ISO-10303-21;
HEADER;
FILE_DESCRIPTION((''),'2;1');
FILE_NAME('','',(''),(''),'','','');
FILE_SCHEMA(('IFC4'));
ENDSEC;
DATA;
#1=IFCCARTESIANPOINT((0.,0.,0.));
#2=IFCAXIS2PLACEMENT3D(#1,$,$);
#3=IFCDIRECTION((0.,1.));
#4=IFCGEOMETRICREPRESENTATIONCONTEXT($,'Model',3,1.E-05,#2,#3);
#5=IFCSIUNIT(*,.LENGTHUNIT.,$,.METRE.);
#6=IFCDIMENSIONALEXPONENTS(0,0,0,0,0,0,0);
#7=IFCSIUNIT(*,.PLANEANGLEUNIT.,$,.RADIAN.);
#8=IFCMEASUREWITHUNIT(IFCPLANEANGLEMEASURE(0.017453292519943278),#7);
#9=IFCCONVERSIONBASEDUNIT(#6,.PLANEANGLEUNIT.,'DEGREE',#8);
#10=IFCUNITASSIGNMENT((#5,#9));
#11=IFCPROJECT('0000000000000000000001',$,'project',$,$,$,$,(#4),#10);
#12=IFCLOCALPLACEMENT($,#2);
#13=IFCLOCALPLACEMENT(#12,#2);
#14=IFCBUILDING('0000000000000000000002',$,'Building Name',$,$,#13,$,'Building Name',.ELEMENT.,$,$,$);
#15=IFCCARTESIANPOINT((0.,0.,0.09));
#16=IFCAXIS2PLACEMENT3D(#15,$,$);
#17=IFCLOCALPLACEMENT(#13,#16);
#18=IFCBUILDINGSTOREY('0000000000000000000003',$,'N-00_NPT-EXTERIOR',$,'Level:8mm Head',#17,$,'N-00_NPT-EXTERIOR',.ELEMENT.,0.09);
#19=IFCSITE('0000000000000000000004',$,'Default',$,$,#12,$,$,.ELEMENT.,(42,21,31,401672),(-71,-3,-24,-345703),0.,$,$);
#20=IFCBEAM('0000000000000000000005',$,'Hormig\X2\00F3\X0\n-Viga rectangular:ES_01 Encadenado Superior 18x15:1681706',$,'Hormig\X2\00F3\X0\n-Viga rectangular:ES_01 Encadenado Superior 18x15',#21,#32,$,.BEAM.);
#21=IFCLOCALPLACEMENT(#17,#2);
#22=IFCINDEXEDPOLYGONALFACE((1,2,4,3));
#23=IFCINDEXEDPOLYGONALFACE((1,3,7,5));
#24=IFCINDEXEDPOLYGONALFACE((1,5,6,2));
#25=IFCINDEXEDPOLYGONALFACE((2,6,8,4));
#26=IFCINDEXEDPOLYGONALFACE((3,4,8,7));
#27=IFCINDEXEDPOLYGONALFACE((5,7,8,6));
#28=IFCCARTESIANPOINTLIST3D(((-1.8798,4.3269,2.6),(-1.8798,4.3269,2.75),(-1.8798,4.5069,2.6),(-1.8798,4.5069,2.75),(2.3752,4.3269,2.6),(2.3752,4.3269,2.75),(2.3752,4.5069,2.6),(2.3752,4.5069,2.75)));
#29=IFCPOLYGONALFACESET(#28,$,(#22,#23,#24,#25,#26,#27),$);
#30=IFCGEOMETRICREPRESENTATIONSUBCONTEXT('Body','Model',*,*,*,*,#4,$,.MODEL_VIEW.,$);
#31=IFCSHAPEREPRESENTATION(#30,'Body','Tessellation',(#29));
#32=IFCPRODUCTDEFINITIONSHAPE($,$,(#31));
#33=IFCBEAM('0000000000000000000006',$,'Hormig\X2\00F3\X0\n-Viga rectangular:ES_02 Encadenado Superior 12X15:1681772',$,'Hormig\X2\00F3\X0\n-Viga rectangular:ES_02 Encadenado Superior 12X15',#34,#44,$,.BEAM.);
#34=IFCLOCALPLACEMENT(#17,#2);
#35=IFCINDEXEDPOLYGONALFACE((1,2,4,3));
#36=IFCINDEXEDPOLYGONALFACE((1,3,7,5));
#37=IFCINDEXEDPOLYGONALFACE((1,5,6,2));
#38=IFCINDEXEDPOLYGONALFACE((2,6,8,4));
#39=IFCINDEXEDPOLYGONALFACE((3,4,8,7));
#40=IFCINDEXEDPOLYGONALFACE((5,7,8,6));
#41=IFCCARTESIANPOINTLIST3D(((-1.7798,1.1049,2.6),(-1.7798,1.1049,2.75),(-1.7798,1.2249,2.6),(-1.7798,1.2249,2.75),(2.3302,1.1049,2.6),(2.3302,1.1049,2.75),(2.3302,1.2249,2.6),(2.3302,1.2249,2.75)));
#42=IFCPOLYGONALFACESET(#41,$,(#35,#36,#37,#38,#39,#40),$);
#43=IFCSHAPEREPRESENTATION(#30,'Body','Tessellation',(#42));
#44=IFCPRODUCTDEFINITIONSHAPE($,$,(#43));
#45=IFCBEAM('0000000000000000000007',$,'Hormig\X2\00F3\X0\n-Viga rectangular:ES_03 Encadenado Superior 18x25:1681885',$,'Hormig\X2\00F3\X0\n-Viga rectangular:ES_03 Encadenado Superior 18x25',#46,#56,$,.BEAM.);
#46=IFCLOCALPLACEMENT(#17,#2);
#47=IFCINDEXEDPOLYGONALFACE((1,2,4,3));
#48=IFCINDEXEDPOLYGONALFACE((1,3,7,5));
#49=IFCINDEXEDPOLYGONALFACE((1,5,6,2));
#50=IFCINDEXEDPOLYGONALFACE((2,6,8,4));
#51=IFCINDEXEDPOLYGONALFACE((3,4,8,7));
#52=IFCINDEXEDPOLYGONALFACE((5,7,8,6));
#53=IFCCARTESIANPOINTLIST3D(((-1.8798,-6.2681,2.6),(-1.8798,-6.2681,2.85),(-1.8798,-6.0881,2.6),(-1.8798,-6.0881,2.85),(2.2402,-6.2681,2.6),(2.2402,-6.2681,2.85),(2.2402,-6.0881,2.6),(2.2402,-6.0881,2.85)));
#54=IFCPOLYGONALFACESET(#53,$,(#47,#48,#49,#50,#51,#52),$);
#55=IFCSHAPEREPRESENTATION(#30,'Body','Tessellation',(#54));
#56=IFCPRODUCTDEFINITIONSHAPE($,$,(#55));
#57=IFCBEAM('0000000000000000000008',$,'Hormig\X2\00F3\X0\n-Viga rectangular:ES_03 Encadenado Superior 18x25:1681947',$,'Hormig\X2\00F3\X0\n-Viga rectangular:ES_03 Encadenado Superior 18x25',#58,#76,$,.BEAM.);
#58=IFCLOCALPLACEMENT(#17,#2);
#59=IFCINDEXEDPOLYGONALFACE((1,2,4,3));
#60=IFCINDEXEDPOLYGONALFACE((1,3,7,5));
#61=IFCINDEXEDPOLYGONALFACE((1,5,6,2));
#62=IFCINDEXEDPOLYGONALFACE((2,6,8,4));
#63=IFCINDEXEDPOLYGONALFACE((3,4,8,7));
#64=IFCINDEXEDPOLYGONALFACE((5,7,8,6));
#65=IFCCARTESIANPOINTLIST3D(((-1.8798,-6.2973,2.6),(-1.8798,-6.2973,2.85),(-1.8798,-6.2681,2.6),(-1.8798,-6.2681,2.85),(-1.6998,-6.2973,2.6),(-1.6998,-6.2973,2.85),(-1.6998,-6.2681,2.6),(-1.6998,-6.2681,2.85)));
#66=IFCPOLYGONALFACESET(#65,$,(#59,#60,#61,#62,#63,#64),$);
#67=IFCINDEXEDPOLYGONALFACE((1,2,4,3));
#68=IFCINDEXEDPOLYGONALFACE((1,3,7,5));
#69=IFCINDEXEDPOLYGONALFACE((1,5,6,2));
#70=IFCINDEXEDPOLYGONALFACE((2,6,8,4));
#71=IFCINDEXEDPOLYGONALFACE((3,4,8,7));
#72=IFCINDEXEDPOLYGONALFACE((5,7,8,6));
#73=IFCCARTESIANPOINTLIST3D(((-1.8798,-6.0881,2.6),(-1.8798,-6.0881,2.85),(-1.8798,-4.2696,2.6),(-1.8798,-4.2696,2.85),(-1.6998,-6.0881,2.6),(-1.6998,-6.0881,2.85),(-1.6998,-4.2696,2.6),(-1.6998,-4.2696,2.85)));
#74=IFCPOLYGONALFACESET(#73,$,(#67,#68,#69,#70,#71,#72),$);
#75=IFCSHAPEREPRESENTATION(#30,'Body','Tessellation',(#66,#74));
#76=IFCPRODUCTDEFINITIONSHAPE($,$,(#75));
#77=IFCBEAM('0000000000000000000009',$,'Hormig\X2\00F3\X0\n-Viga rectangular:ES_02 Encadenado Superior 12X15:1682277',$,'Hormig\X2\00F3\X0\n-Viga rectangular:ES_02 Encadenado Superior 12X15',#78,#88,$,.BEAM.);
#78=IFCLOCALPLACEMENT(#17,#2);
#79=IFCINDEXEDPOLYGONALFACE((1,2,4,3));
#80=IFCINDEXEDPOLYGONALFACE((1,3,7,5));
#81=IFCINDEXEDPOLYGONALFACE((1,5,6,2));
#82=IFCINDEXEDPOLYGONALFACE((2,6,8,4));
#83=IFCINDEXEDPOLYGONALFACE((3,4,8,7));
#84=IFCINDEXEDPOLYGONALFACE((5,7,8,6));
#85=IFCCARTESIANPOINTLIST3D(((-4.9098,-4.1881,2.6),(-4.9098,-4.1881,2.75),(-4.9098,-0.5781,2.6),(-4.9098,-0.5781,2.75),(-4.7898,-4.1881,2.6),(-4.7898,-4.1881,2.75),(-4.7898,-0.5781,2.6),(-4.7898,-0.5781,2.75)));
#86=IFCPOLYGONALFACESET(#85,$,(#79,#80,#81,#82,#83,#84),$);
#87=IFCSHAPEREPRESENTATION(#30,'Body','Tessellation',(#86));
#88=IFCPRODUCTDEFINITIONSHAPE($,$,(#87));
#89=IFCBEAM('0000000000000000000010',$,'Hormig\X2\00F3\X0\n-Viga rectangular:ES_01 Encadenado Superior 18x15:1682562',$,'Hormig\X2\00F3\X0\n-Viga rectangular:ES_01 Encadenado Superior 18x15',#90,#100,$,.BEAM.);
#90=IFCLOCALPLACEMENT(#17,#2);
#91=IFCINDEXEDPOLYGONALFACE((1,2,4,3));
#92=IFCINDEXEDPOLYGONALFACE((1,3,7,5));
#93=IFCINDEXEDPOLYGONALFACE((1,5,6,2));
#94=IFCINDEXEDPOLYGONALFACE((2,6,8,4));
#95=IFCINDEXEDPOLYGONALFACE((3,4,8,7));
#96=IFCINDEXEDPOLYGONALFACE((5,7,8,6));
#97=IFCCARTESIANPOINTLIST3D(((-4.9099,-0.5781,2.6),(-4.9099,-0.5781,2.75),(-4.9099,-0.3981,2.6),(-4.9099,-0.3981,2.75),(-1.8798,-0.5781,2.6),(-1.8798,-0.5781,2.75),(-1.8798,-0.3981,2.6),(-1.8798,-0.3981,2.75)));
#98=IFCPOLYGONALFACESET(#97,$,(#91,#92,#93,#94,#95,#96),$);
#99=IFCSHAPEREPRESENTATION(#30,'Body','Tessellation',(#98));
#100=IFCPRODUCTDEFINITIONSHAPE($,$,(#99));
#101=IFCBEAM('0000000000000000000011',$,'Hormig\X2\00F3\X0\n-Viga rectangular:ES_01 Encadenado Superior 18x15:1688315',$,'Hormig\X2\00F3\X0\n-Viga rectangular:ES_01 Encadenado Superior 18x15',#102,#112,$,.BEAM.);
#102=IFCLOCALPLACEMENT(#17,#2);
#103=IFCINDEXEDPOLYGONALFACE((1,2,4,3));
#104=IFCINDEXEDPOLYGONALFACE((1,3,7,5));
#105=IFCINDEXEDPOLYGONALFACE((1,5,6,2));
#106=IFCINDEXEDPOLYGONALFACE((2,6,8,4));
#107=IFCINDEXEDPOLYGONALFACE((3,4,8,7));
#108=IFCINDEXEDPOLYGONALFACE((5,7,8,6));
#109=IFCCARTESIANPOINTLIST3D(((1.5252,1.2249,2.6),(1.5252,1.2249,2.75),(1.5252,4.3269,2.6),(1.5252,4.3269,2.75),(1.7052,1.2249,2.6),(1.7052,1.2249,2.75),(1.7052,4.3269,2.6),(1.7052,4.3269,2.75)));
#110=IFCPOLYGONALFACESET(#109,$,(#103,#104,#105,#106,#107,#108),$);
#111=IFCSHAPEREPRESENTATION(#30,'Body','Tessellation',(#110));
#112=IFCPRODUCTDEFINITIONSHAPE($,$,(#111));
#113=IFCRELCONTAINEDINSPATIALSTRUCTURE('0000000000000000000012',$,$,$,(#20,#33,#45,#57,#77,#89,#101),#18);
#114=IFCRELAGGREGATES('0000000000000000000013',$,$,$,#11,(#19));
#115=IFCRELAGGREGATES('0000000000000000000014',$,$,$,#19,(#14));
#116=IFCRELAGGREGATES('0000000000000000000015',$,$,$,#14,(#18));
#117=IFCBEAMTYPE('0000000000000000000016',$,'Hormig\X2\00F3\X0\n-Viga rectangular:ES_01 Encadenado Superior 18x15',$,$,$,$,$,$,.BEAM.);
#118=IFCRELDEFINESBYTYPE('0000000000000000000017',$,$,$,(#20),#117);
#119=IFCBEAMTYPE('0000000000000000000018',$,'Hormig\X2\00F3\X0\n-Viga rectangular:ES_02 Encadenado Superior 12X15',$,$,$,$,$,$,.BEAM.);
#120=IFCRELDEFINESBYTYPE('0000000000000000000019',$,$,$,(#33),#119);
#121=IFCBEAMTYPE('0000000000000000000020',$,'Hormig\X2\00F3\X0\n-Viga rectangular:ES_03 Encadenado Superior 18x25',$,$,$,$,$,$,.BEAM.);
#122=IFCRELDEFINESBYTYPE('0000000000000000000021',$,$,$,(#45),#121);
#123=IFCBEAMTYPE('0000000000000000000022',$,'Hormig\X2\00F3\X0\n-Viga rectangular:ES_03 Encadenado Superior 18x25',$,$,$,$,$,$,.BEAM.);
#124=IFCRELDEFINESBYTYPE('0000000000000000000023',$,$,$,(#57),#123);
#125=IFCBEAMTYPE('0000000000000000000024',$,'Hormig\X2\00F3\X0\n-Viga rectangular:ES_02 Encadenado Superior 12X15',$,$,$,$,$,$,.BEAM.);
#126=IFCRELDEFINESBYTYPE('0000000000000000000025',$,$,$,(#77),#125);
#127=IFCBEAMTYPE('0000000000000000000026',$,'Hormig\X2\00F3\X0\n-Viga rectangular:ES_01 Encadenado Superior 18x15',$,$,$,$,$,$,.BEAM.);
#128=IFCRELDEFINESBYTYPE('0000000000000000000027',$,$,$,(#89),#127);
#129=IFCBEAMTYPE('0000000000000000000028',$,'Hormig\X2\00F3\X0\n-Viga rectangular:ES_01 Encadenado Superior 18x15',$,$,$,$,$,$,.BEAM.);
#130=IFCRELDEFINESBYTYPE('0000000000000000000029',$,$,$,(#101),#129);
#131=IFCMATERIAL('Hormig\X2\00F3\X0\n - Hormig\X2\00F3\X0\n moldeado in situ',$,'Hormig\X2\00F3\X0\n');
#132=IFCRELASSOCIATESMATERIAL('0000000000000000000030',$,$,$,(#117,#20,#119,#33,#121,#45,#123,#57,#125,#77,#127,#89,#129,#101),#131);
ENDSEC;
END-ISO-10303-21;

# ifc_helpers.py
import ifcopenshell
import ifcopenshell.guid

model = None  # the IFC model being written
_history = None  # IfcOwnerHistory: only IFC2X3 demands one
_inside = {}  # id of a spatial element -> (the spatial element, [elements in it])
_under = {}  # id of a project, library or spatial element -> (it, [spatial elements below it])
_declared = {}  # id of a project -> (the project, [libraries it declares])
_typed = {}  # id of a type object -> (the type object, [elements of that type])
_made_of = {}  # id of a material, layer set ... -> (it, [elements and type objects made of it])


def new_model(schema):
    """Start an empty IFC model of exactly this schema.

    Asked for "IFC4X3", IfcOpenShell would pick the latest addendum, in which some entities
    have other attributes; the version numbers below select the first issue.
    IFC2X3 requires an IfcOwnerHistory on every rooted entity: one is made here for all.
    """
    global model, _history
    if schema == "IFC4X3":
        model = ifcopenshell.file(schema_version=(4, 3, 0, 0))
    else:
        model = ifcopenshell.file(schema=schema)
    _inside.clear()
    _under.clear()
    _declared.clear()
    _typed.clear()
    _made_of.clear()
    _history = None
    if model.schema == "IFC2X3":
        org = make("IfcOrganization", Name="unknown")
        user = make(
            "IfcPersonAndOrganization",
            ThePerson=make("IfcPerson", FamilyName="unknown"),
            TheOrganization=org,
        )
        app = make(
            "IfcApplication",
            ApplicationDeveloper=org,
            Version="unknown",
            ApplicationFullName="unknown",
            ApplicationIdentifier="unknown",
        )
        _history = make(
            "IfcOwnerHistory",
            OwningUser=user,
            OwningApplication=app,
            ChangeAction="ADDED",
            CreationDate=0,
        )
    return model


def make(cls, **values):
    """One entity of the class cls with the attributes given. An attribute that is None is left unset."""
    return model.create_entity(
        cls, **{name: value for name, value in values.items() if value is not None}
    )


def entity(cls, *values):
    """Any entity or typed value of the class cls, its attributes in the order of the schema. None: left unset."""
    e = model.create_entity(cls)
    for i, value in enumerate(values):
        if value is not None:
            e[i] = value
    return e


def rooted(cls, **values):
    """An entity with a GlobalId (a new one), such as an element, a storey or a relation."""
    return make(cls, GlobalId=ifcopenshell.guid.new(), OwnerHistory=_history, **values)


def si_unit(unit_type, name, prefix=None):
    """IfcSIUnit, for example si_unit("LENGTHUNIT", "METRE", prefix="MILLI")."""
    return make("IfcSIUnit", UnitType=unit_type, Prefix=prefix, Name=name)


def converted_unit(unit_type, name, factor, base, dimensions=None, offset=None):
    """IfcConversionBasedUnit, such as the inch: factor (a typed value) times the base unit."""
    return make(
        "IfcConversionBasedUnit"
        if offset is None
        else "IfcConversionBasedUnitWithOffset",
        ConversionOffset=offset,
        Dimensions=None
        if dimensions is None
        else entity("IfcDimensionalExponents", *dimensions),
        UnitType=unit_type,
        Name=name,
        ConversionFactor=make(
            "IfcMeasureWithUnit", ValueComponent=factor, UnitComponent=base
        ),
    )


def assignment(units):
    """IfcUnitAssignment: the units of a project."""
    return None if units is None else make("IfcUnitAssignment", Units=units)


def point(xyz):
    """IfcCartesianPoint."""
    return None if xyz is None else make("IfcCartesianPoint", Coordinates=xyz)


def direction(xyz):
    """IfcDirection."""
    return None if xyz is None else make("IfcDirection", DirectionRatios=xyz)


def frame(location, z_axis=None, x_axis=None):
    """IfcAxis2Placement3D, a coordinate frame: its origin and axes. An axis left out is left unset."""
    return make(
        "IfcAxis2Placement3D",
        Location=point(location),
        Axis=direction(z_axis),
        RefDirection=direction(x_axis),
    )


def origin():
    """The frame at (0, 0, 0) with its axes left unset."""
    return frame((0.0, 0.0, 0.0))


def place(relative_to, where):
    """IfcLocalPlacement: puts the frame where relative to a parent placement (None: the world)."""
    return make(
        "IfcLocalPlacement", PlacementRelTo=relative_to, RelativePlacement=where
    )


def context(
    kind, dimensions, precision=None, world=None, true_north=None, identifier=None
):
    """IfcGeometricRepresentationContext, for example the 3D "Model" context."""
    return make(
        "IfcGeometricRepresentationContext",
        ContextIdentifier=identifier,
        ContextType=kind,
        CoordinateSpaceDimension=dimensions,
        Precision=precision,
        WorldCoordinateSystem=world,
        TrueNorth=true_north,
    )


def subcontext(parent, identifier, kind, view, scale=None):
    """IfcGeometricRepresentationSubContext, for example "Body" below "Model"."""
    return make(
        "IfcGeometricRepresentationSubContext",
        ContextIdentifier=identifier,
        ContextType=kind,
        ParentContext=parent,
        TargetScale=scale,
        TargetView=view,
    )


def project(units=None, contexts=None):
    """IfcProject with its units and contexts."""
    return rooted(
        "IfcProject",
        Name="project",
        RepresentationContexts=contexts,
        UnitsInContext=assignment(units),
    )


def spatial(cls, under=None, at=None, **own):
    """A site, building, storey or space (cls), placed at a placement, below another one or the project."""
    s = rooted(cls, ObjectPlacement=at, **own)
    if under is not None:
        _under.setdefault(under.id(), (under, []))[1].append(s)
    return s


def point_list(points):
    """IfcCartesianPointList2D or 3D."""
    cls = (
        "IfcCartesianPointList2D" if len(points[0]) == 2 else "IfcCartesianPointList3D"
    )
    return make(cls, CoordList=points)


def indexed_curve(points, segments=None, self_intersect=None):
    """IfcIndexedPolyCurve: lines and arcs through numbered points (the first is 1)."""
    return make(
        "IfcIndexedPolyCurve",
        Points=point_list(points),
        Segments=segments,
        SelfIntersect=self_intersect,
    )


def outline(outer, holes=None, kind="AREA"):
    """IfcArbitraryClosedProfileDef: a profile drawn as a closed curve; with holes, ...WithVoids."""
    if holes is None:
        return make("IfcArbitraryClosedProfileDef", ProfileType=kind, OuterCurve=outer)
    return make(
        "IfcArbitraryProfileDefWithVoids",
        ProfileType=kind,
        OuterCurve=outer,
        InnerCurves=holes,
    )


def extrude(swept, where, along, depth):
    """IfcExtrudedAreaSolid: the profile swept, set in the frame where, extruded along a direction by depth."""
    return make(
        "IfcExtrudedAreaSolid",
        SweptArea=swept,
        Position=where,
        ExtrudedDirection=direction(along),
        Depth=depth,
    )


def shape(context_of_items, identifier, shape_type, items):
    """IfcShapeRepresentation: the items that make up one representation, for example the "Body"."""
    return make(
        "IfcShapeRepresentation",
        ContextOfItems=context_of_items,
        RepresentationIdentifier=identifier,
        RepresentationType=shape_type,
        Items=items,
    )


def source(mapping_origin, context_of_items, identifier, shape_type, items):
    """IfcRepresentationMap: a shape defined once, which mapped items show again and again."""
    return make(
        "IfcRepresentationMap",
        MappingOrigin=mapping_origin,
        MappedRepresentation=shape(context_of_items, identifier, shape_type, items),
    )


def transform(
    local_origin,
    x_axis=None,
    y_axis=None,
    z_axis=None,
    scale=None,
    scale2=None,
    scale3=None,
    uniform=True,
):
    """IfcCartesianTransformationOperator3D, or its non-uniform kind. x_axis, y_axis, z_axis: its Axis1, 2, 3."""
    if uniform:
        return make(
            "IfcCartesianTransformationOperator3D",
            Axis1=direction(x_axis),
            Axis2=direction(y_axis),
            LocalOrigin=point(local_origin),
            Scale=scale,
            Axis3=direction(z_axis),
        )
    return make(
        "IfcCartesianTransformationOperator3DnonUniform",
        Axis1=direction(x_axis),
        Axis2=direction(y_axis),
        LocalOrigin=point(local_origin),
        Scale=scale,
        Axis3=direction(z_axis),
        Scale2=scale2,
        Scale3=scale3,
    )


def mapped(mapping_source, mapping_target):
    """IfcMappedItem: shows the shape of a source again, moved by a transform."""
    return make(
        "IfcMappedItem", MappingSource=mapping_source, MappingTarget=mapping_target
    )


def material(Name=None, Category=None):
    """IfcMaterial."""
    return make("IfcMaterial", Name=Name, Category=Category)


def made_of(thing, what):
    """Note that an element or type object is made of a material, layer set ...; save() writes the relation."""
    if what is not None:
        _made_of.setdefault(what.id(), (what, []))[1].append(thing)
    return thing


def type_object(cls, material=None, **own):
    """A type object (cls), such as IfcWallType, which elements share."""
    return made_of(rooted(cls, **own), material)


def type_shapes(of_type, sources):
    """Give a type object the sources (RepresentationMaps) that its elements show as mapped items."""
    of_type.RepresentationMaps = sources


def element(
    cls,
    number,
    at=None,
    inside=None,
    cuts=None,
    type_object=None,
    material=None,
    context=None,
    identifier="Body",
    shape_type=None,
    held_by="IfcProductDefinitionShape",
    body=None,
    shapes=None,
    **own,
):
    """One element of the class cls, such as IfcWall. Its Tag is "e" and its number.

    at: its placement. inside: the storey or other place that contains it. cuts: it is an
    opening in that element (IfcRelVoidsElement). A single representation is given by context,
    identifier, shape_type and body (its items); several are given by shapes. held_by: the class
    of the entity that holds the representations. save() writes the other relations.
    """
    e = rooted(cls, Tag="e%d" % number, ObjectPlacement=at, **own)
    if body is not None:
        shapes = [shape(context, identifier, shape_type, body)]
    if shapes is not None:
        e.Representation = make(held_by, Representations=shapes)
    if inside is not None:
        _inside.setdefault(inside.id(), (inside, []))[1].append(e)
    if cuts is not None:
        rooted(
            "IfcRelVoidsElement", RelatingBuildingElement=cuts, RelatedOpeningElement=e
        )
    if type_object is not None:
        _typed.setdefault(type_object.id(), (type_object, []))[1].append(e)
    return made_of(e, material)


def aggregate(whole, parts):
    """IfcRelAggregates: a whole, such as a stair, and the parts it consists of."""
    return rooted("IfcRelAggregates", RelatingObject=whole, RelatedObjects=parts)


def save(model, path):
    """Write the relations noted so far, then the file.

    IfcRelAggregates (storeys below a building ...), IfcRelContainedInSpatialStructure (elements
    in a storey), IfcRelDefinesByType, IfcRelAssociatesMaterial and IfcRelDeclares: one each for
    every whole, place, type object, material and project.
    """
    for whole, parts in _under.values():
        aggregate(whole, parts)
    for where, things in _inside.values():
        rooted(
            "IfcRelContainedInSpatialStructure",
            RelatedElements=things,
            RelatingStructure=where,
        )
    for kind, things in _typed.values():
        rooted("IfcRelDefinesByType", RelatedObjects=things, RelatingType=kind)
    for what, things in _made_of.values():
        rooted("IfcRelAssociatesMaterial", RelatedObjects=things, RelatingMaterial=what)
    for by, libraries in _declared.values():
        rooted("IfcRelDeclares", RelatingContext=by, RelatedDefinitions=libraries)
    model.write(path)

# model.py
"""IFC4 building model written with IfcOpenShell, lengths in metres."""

from ifc_helpers import new_model, entity, si_unit, converted_unit, direction, frame, origin, place, context, subcontext, project, spatial, indexed_curve, outline, extrude, source, transform, mapped, material, type_object, type_shapes, element, save


model = new_model("IFC4")

# Units and contexts
model_context = context("Model", 3, precision=1e-05, world=origin(), true_north=direction((0.0, 1.0)))
body_context = subcontext(model_context, "Body", "Model", "MODEL_VIEW")
ifc_project = project(units=[si_unit("LENGTHUNIT", "METRE"), converted_unit("PLANEANGLEUNIT", "DEGREE", entity("IfcPlaneAngleMeasure", 0.017453292519943278), si_unit("PLANEANGLEUNIT", "RADIAN"), dimensions=[0, 0, 0, 0, 0, 0, 0])], contexts=[model_context])

# Site, building, storey
site_placement = place(None, origin())
site = spatial("IfcSite", under=ifc_project, at=site_placement, Name="Default", CompositionType="ELEMENT", RefLatitude=(42, 21, 31, 401672), RefLongitude=(-71, -3, -24, -345703), RefElevation=0.0)
building_placement = place(site_placement, origin())
building = spatial("IfcBuilding", under=site, at=building_placement, Name="Building Name", LongName="Building Name", CompositionType="ELEMENT")
storey_placement = place(building_placement, frame((0.0, 0.0, 0.09)))
storey = spatial("IfcBuildingStorey", under=building, at=storey_placement, Name="N-00_NPT-EXTERIOR", ObjectType="Level:8mm Head", LongName="N-00_NPT-EXTERIOR", CompositionType="ELEMENT", Elevation=0.09)

# Beams
ifc_material_1 = material(Name="Hormigón - Hormigón moldeado in situ", Category="Hormigón")
beam_type_1 = type_object("IfcBeamType", Name="Hormigón-Viga rectangular:ES_01 Encadenado Superior 18x15", PredefinedType="BEAM", material=ifc_material_1)
shared_shape_1 = source(origin(), body_context, "Body", "SweptSolid", [
    extrude(outline(indexed_curve([(-0.075, -0.09), (0.075, -0.09), (0.075, 0.09), (-0.075, 0.09), (-0.075, -0.09)], self_intersect=False)), frame((2.3752, 4.4169, 2.765), z_axis=(-1.0, 0.0, 0.0), x_axis=(0.0, 0.0, -1.0)), (0.0, 0.0, 1.0), 4.255),
])
type_shapes(beam_type_1, [shared_shape_1])
beam_1_placement = place(storey_placement, frame((0.0, 0.0, -0.09)))
element("IfcBeam", 1, at=beam_1_placement, inside=storey, type_object=beam_type_1, material=ifc_material_1, Name="Hormigón-Viga rectangular:ES_01 Encadenado Superior 18x15:1681706", ObjectType="Hormigón-Viga rectangular:ES_01 Encadenado Superior 18x15", PredefinedType="BEAM", context=body_context, shape_type="MappedRepresentation", body=[
    mapped(shared_shape_1, transform((0.0, 0.0, 0.0), scale=1.0)),
])
beam_type_2 = type_object("IfcBeamType", Name="Hormigón-Viga rectangular:ES_02 Encadenado Superior 12X15", PredefinedType="BEAM", material=ifc_material_1)
shared_shape_2 = source(origin(), body_context, "Body", "SweptSolid", [
    extrude(outline(indexed_curve([(-0.075, -0.06), (0.075, -0.06), (0.075, 0.06), (-0.075, 0.06), (-0.075, -0.06)], self_intersect=False)), frame((2.3302, 1.1649, 2.765), z_axis=(-1.0, 0.0, 0.0), x_axis=(0.0, 0.0, -1.0)), (0.0, 0.0, 1.0), 4.11),
])
type_shapes(beam_type_2, [shared_shape_2])
beam_2_placement = place(storey_placement, frame((0.0, 0.0, -0.09)))
element("IfcBeam", 2, at=beam_2_placement, inside=storey, type_object=beam_type_2, material=ifc_material_1, Name="Hormigón-Viga rectangular:ES_02 Encadenado Superior 12X15:1681772", ObjectType="Hormigón-Viga rectangular:ES_02 Encadenado Superior 12X15", PredefinedType="BEAM", context=body_context, shape_type="MappedRepresentation", body=[
    mapped(shared_shape_2, transform((0.0, 0.0, 0.0), scale=1.0)),
])
beam_type_3 = type_object("IfcBeamType", Name="Hormigón-Viga rectangular:ES_03 Encadenado Superior 18x25", PredefinedType="BEAM", material=ifc_material_1)
shared_shape_3 = source(origin(), body_context, "Body", "SweptSolid", [
    extrude(outline(indexed_curve([(-0.125, -0.09), (0.125, -0.09), (0.125, 0.09), (-0.125, 0.09), (-0.125, -0.09)], self_intersect=False)), frame((2.2402, -6.1781, 2.815), z_axis=(-1.0, 0.0, 0.0), x_axis=(0.0, 0.0, -1.0)), (0.0, 0.0, 1.0), 4.12),
])
type_shapes(beam_type_3, [shared_shape_3])
beam_3_placement = place(storey_placement, frame((0.0, 0.0, -0.09)))
element("IfcBeam", 3, at=beam_3_placement, inside=storey, type_object=beam_type_3, material=ifc_material_1, Name="Hormigón-Viga rectangular:ES_03 Encadenado Superior 18x25:1681885", ObjectType="Hormigón-Viga rectangular:ES_03 Encadenado Superior 18x25", PredefinedType="BEAM", context=body_context, shape_type="MappedRepresentation", body=[
    mapped(shared_shape_3, transform((0.0, 0.0, 0.0), scale=1.0)),
])
beam_type_4 = type_object("IfcBeamType", Name="Hormigón-Viga rectangular:ES_03 Encadenado Superior 18x25", PredefinedType="BEAM", material=ifc_material_1)
shared_shape_4 = source(origin(), body_context, "Body", "SweptSolid", [
    extrude(outline(indexed_curve([(-0.09, -0.125), (0.09, -0.125), (0.09, 0.125), (-0.09, 0.125), (-0.09, -0.125)], self_intersect=False)), frame((-1.7898, -6.2973, 2.815), z_axis=(0.0, 1.0, 0.0), x_axis=(-1.0, 0.0, 0.0)), (0.0, 0.0, 1.0), 0.0291),
    extrude(outline(indexed_curve([(-0.09, -0.125), (0.09, -0.125), (0.09, 0.125), (-0.09, 0.125), (-0.09, -0.125)], self_intersect=False)), frame((-1.7898, -6.0881, 2.815), z_axis=(0.0, 1.0, 0.0), x_axis=(-1.0, 0.0, 0.0)), (0.0, 0.0, 1.0), 1.8186),
])
type_shapes(beam_type_4, [shared_shape_4])
beam_4_placement = place(storey_placement, frame((0.0, 0.0, -0.09)))
element("IfcBeam", 4, at=beam_4_placement, inside=storey, type_object=beam_type_4, material=ifc_material_1, Name="Hormigón-Viga rectangular:ES_03 Encadenado Superior 18x25:1681947", ObjectType="Hormigón-Viga rectangular:ES_03 Encadenado Superior 18x25", PredefinedType="BEAM", context=body_context, shape_type="MappedRepresentation", body=[
    mapped(shared_shape_4, transform((0.0, 0.0, 0.0), scale=1.0)),
])
beam_type_5 = type_object("IfcBeamType", Name="Hormigón-Viga rectangular:ES_02 Encadenado Superior 12X15", PredefinedType="BEAM", material=ifc_material_1)
shared_shape_5 = source(origin(), body_context, "Body", "SweptSolid", [
    extrude(outline(indexed_curve([(-0.06, -0.075), (0.06, -0.075), (0.06, 0.075), (-0.06, 0.075), (-0.06, -0.075)], self_intersect=False)), frame((-4.8498, -4.1881, 2.765), z_axis=(0.0, 1.0, 0.0), x_axis=(-1.0, 0.0, 0.0)), (0.0, 0.0, 1.0), 3.61),
])
type_shapes(beam_type_5, [shared_shape_5])
beam_5_placement = place(storey_placement, frame((0.0, 0.0, -0.09)))
element("IfcBeam", 5, at=beam_5_placement, inside=storey, type_object=beam_type_5, material=ifc_material_1, Name="Hormigón-Viga rectangular:ES_02 Encadenado Superior 12X15:1682277", ObjectType="Hormigón-Viga rectangular:ES_02 Encadenado Superior 12X15", PredefinedType="BEAM", context=body_context, shape_type="MappedRepresentation", body=[
    mapped(shared_shape_5, transform((0.0, 0.0, 0.0), scale=1.0)),
])
beam_type_6 = type_object("IfcBeamType", Name="Hormigón-Viga rectangular:ES_01 Encadenado Superior 18x15", PredefinedType="BEAM", material=ifc_material_1)
shared_shape_6 = source(origin(), body_context, "Body", "SweptSolid", [
    extrude(outline(indexed_curve([(-0.075, -0.09), (0.075, -0.09), (0.075, 0.09), (-0.075, 0.09), (-0.075, -0.09)], self_intersect=False)), frame((-4.9099, -0.4881, 2.765), z_axis=(1.0, 0.0, 0.0), x_axis=(0.0, 0.0, -1.0)), (0.0, 0.0, 1.0), 3.0302),
])
type_shapes(beam_type_6, [shared_shape_6])
beam_6_placement = place(storey_placement, frame((0.0, 0.0, -0.09)))
element("IfcBeam", 6, at=beam_6_placement, inside=storey, type_object=beam_type_6, material=ifc_material_1, Name="Hormigón-Viga rectangular:ES_01 Encadenado Superior 18x15:1682562", ObjectType="Hormigón-Viga rectangular:ES_01 Encadenado Superior 18x15", PredefinedType="BEAM", context=body_context, shape_type="MappedRepresentation", body=[
    mapped(shared_shape_6, transform((0.0, 0.0, 0.0), scale=1.0)),
])
beam_type_7 = type_object("IfcBeamType", Name="Hormigón-Viga rectangular:ES_01 Encadenado Superior 18x15", PredefinedType="BEAM", material=ifc_material_1)
shared_shape_7 = source(origin(), body_context, "Body", "SweptSolid", [
    extrude(outline(indexed_curve([(-0.09, -0.075), (0.09, -0.075), (0.09, 0.075), (-0.09, 0.075), (-0.09, -0.075)], self_intersect=False)), frame((1.6152, 1.2249, 2.765), z_axis=(0.0, 1.0, 0.0), x_axis=(-1.0, 0.0, 0.0)), (0.0, 0.0, 1.0), 3.102),
])
type_shapes(beam_type_7, [shared_shape_7])
beam_7_placement = place(storey_placement, frame((0.0, 0.0, -0.09)))
element("IfcBeam", 7, at=beam_7_placement, inside=storey, type_object=beam_type_7, material=ifc_material_1, Name="Hormigón-Viga rectangular:ES_01 Encadenado Superior 18x15:1688315", ObjectType="Hormigón-Viga rectangular:ES_01 Encadenado Superior 18x15", PredefinedType="BEAM", context=body_context, shape_type="MappedRepresentation", body=[
    mapped(shared_shape_7, transform((0.0, 0.0, 0.0), scale=1.0)),
])

save(model, "model.ifc")
